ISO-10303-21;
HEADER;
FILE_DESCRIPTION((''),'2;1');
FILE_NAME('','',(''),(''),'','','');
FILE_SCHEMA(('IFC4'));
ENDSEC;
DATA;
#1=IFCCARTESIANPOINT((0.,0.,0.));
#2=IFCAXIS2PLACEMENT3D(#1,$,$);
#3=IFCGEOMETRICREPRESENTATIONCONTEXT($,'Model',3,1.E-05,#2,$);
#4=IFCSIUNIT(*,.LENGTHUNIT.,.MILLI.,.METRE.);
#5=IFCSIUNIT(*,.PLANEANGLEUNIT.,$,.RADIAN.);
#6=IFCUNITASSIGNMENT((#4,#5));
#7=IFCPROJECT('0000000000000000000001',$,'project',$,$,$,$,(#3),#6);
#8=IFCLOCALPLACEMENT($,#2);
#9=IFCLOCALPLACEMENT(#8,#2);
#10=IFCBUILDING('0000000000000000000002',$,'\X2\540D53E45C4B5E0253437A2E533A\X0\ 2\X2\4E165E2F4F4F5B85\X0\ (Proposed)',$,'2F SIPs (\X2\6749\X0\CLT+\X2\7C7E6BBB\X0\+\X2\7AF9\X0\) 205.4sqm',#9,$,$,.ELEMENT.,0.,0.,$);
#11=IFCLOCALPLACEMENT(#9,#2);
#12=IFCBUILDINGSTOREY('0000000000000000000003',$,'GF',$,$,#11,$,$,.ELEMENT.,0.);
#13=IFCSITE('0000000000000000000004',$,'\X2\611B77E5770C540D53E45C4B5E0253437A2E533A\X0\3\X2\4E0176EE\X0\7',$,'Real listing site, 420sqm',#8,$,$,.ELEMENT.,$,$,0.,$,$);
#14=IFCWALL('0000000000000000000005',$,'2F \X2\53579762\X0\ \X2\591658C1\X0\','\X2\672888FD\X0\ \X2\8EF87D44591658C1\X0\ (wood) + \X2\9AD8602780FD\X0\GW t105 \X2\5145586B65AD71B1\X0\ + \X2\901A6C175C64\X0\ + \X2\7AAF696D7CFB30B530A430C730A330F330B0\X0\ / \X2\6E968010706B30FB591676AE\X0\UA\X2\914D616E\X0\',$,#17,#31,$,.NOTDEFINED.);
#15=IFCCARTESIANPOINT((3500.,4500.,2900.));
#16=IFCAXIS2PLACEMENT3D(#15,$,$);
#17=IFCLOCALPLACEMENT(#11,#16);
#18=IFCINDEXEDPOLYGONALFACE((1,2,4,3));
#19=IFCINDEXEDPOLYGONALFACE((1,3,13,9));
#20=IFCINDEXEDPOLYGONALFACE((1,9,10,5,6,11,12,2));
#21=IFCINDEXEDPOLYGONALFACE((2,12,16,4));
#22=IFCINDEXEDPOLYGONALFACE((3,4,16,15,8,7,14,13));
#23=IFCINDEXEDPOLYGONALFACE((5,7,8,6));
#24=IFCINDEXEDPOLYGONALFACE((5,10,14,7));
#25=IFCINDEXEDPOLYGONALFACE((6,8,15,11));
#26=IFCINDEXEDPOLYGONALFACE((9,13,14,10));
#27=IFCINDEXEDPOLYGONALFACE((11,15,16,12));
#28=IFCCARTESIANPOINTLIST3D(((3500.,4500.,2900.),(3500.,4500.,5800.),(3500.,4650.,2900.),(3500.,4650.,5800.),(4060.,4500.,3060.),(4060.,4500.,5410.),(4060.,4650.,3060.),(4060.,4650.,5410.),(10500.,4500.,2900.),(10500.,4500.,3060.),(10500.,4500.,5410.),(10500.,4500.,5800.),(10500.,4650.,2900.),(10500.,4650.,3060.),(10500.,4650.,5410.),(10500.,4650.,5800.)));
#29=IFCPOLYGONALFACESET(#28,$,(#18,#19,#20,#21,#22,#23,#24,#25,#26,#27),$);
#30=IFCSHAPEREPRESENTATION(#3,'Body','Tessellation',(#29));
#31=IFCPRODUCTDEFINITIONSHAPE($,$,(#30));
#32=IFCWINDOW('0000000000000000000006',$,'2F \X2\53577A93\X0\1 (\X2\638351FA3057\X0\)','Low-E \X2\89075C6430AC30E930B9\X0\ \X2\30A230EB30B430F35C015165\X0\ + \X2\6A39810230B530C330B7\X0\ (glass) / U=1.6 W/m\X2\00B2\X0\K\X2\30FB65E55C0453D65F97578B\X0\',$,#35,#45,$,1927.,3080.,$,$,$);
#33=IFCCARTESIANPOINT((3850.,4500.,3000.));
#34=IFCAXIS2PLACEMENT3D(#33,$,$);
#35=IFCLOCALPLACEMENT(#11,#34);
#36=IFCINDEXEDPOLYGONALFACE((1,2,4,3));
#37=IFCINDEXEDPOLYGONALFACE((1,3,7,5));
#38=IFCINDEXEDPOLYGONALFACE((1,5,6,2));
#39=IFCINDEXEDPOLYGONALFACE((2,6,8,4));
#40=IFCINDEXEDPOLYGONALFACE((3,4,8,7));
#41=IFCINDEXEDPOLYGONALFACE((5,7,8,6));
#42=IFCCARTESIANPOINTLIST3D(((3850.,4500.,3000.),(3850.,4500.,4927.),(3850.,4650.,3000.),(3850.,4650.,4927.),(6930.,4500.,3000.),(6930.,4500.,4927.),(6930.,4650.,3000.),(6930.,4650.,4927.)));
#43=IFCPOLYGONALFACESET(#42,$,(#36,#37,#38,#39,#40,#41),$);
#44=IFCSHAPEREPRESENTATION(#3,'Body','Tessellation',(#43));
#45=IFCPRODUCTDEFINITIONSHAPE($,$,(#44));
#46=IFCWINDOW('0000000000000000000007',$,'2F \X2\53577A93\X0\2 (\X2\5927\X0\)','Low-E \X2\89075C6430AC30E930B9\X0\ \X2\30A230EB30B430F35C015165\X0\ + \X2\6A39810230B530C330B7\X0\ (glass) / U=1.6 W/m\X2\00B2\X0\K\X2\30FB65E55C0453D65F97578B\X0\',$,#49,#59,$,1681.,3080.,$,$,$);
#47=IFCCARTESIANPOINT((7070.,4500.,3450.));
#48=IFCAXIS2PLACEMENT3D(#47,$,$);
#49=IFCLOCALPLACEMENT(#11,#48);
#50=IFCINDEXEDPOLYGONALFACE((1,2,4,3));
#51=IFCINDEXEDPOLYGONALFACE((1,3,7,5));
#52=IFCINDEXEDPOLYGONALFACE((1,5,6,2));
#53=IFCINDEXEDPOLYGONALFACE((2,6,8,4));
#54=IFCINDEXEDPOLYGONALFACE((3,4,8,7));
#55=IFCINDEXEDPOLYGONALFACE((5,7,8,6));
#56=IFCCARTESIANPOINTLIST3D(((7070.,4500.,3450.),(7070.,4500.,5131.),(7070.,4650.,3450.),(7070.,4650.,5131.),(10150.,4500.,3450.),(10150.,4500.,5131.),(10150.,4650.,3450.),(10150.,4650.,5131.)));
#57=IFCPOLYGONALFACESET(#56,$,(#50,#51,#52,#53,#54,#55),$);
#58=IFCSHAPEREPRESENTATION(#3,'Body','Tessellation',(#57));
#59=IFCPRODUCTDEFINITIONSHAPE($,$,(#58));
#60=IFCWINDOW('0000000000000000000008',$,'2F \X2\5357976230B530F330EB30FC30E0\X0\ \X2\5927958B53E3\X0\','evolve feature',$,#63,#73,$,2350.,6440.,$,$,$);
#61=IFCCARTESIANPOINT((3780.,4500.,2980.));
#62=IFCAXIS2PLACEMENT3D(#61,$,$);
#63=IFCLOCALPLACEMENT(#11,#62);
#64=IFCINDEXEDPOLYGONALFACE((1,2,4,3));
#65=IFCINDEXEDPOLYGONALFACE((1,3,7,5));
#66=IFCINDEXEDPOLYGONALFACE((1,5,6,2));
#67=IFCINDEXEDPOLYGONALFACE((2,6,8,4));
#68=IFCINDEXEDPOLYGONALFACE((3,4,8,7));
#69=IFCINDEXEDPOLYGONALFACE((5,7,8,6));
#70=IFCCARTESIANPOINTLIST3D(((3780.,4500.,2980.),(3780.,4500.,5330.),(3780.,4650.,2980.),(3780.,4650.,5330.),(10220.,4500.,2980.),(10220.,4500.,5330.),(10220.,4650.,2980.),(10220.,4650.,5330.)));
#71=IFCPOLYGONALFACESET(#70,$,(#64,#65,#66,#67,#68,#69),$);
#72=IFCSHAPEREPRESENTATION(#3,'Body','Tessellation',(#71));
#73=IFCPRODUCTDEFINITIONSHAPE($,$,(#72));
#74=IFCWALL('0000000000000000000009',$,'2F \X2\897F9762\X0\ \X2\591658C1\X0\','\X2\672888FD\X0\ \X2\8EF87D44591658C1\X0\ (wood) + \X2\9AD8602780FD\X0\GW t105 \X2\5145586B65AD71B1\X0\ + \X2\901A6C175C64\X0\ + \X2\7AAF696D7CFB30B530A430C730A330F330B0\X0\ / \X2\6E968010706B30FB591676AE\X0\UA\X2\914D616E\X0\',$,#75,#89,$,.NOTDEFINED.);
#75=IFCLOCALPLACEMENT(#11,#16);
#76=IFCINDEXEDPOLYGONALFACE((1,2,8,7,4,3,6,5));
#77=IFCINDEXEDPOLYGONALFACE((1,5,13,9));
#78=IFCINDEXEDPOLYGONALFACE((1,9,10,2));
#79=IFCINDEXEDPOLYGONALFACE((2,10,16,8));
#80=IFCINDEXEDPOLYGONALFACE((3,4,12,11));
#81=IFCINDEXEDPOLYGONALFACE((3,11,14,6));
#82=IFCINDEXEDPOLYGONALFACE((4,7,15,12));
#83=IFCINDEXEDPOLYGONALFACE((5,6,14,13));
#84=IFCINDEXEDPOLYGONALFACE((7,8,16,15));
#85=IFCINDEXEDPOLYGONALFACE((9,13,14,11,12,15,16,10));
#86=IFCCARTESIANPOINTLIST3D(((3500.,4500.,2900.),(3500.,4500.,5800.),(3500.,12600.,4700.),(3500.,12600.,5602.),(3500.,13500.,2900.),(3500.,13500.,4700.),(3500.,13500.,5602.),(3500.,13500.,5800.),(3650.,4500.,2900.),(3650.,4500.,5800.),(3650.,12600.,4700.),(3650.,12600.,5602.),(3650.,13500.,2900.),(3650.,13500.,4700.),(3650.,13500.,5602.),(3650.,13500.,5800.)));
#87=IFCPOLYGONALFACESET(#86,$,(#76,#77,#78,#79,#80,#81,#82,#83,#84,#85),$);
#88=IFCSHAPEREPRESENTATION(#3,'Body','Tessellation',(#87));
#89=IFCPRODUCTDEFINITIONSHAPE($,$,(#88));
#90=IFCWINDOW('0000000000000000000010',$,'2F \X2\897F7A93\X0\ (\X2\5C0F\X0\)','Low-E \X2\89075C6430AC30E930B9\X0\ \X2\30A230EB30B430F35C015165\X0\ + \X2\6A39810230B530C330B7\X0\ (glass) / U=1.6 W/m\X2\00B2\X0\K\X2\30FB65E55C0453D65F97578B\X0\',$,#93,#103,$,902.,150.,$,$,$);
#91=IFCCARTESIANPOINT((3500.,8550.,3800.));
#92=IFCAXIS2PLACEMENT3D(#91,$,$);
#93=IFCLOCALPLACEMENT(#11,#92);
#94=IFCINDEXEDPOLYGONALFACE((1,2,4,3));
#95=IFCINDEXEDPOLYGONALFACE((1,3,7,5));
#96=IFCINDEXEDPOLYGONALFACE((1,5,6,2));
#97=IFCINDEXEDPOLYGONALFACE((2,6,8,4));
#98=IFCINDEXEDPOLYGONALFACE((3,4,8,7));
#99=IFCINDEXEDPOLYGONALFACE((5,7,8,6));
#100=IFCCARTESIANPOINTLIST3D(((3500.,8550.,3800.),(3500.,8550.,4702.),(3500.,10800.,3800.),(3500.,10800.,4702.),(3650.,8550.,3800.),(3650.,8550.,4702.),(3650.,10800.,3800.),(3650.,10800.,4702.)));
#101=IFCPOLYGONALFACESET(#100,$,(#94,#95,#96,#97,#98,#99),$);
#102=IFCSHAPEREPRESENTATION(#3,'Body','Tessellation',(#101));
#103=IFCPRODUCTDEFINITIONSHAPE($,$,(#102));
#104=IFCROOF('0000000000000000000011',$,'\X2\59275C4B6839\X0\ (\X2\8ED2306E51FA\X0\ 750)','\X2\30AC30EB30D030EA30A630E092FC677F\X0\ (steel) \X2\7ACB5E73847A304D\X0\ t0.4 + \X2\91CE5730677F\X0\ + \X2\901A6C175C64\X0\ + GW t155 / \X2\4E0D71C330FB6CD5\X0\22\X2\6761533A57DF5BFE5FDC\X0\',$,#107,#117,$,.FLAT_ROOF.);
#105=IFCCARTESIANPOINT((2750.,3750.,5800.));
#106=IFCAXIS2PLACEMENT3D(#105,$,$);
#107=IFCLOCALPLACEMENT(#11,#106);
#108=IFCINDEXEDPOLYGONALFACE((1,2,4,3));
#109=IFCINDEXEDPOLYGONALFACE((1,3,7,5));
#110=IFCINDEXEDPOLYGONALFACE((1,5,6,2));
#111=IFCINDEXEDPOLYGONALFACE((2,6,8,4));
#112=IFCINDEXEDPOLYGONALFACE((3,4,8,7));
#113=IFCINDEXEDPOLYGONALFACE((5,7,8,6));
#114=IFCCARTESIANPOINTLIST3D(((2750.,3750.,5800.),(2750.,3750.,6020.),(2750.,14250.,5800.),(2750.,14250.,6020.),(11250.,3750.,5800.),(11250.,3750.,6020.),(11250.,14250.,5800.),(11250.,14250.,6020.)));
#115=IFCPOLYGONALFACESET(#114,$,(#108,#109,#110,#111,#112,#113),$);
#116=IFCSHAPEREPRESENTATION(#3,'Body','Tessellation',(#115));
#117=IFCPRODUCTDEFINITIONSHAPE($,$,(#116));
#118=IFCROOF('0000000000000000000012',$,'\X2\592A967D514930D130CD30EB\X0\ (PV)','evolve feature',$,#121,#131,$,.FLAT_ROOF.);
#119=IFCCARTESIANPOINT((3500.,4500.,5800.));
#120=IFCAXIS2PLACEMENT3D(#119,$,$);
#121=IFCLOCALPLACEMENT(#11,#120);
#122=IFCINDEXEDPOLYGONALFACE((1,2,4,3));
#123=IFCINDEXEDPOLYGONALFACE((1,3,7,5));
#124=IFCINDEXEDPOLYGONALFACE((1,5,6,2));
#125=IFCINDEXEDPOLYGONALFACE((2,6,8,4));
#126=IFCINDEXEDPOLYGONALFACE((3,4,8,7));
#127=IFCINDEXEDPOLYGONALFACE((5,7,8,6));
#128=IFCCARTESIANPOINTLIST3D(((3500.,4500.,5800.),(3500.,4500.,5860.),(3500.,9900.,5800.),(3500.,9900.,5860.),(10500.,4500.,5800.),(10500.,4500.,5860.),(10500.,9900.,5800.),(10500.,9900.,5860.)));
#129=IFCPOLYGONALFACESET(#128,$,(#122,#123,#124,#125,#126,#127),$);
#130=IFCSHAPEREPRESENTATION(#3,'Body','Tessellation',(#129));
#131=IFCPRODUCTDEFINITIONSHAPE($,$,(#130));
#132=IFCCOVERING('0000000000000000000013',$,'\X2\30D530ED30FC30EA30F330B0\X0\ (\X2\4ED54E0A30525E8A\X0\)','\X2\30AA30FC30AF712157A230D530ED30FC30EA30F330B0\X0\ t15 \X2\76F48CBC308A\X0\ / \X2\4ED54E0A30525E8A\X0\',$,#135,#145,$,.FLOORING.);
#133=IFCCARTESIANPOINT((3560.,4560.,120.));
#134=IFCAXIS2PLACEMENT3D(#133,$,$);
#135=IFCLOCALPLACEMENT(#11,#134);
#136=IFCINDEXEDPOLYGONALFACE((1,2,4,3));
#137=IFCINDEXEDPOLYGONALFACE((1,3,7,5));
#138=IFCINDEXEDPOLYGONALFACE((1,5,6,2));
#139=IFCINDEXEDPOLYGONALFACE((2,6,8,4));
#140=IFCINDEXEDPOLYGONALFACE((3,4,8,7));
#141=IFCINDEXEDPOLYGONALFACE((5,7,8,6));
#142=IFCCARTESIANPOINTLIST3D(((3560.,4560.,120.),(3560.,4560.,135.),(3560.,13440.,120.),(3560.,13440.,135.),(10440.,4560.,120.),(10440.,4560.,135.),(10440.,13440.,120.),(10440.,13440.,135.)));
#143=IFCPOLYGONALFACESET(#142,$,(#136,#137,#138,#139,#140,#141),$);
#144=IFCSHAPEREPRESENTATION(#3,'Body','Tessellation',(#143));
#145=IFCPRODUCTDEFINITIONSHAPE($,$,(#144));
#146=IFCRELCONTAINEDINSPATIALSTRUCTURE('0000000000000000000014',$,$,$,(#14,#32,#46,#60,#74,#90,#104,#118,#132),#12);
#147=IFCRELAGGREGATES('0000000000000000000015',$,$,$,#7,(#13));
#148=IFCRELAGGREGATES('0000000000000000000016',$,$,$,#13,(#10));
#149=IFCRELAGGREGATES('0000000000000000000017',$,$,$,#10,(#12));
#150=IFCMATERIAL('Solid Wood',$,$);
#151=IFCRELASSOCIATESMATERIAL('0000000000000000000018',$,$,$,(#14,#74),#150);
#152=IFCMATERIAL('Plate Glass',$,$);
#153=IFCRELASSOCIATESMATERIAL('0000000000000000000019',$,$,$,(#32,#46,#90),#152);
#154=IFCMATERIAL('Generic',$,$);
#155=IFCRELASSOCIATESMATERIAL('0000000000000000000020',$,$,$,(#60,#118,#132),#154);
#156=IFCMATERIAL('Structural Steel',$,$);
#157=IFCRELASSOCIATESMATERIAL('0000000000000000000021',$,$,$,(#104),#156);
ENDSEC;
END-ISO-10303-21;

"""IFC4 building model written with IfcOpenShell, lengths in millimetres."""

from ifc_helpers import new_model, si_unit, frame, frame_2d, origin, place, context, project, spatial, rectangle, extrude, material, element, fill, save


model = new_model("IFC4")

# Units and contexts
model_context = context("Model", 3, precision=1e-05, world=origin())
ifc_project = project(units=[si_unit("LENGTHUNIT", "METRE", prefix="MILLI"), si_unit("PLANEANGLEUNIT", "RADIAN")], contexts=[model_context])

# Site, building, storey
site_placement = place(None, origin())
site = spatial("IfcSite", under=ifc_project, at=site_placement, Name="愛知県名古屋市千種区3丁目7", ObjectType="Real listing site, 420sqm", CompositionType="ELEMENT", RefElevation=0.0)
building_placement = place(site_placement, origin())
building = spatial("IfcBuilding", under=site, at=building_placement, Name="名古屋市千種区 2世帯住宅 (Proposed)", ObjectType="2F SIPs (杉CLT+籾殻+竹) 205.4sqm", CompositionType="ELEMENT", ElevationOfRefHeight=0.0, ElevationOfTerrain=0.0)
storey_placement = place(building_placement, origin())
storey = spatial("IfcBuildingStorey", under=building, at=storey_placement, Name="GF", CompositionType="ELEMENT", Elevation=0.0)

# Shared definitions
ifc_material_1 = material(Name="Solid Wood")

# Shared definitions
ifc_material_2 = material(Name="Plate Glass")
ifc_material_3 = material(Name="Generic")

# Wall, openings, windows
wall_1_placement = place(storey_placement, frame((3500.0, 4500.0, 2900.0)))
wall_1 = element("IfcWall", 1, at=wall_1_placement, inside=storey, material=ifc_material_1, Name="2F 南面 外壁", Description="木製 軸組外壁 (wood) + 高性能GW t105 充填断熱 + 通気層 + 窯業系サイディング / 準耐火・外皮UA配慮", PredefinedType="NOTDEFINED", context=model_context, shape_type="SweptSolid", body=[
    extrude(rectangle(XDim=7000.0, YDim=150.0, at=frame_2d((3500.0, 75.0))), frame((3500.0, 4500.0, 2900.0)), (0.0, 0.0, 1.0), 2900.0),
])
opening_1_placement = place(storey_placement, frame((3850.0, 4500.0, 3000.0)))
opening_1 = element("IfcOpeningElement", 2, at=opening_1_placement, cuts=wall_1, PredefinedType="NOTDEFINED", context=model_context, shape_type="SweptSolid", body=[
    extrude(rectangle(XDim=3080.0, YDim=150.0, at=frame_2d((1540.0, 75.0))), frame((3850.0, 4500.0, 3000.0)), (0.0, 0.0, 1.0), 1927.0),
])
opening_2_placement = place(storey_placement, frame((7070.0, 4500.0, 3450.0)))
opening_2 = element("IfcOpeningElement", 3, at=opening_2_placement, cuts=wall_1, PredefinedType="NOTDEFINED", context=model_context, shape_type="SweptSolid", body=[
    extrude(rectangle(XDim=3080.0, YDim=150.0, at=frame_2d((1540.0, 75.0))), frame((7070.0, 4500.0, 3450.0)), (0.0, 0.0, 1.0), 1681.0),
])
opening_3_placement = place(storey_placement, frame((3780.0, 4500.0, 2980.0)))
opening_3 = element("IfcOpeningElement", 4, at=opening_3_placement, cuts=wall_1, PredefinedType="NOTDEFINED", context=model_context, shape_type="SweptSolid", body=[
    extrude(rectangle(XDim=6440.0, YDim=150.0, at=frame_2d((3220.0, 75.0))), frame((3780.0, 4500.0, 2980.0)), (0.0, 0.0, 1.0), 2350.0),
])
window_1_placement = place(storey_placement, frame((3850.0, 4500.0, 3000.0)))
window_1 = element("IfcWindow", 5, at=window_1_placement, inside=storey, material=ifc_material_2, Name="2F 南窓1 (掃出し)", Description="Low-E 複層ガラス アルゴン封入 + 樹脂サッシ (glass) / U=1.6 W/m²K・日射取得型", OverallHeight=1927.0, OverallWidth=3080.0, context=model_context, shape_type="SweptSolid", body=[
    extrude(rectangle(XDim=3080.0, YDim=150.0, at=frame_2d((1540.0, 75.0))), frame((3850.0, 4500.0, 3000.0)), (0.0, 0.0, 1.0), 1927.0),
])
fill(opening_1, window_1)
window_2_placement = place(storey_placement, frame((7070.0, 4500.0, 3450.0)))
window_2 = element("IfcWindow", 6, at=window_2_placement, inside=storey, material=ifc_material_2, Name="2F 南窓2 (大)", Description="Low-E 複層ガラス アルゴン封入 + 樹脂サッシ (glass) / U=1.6 W/m²K・日射取得型", OverallHeight=1681.0, OverallWidth=3080.0, context=model_context, shape_type="SweptSolid", body=[
    extrude(rectangle(XDim=3080.0, YDim=150.0, at=frame_2d((1540.0, 75.0))), frame((7070.0, 4500.0, 3450.0)), (0.0, 0.0, 1.0), 1681.0),
])
fill(opening_2, window_2)
window_3_placement = place(storey_placement, frame((3780.0, 4500.0, 2980.0)))
window_3 = element("IfcWindow", 7, at=window_3_placement, inside=storey, material=ifc_material_3, Name="2F 南面サンルーム 大開口", Description="evolve feature", OverallHeight=2350.0, OverallWidth=6440.0, context=model_context, shape_type="SweptSolid", body=[
    extrude(rectangle(XDim=6440.0, YDim=150.0, at=frame_2d((3220.0, 75.0))), frame((3780.0, 4500.0, 2980.0)), (0.0, 0.0, 1.0), 2350.0),
])
fill(opening_3, window_3)

# Wall, opening, window
wall_2_placement = place(storey_placement, frame((3500.0, 4500.0, 2900.0)))
wall_2 = element("IfcWall", 8, at=wall_2_placement, inside=storey, material=ifc_material_1, Name="2F 西面 外壁", Description="木製 軸組外壁 (wood) + 高性能GW t105 充填断熱 + 通気層 + 窯業系サイディング / 準耐火・外皮UA配慮", PredefinedType="NOTDEFINED", context=model_context, shape_type="SweptSolid", body=[
    extrude(rectangle(XDim=150.0, YDim=9000.0, at=frame_2d((75.0, 4500.0))), frame((3500.0, 4500.0, 2900.0)), (0.0, 0.0, 1.0), 2900.0),
])
opening_4_placement = place(storey_placement, frame((3500.0, 8550.0, 3800.0)))
opening_4 = element("IfcOpeningElement", 9, at=opening_4_placement, cuts=wall_2, PredefinedType="NOTDEFINED", context=model_context, shape_type="SweptSolid", body=[
    extrude(rectangle(XDim=150.0, YDim=2250.0, at=frame_2d((75.0, 1125.0))), frame((3500.0, 8550.0, 3800.0)), (0.0, 0.0, 1.0), 902.0),
])
window_4_placement = place(storey_placement, frame((3500.0, 8550.0, 3800.0)))
window_4 = element("IfcWindow", 10, at=window_4_placement, inside=storey, material=ifc_material_2, Name="2F 西窓 (小)", Description="Low-E 複層ガラス アルゴン封入 + 樹脂サッシ (glass) / U=1.6 W/m²K・日射取得型", OverallHeight=902.0, OverallWidth=150.0, context=model_context, shape_type="SweptSolid", body=[
    extrude(rectangle(XDim=150.0, YDim=2250.0, at=frame_2d((75.0, 1125.0))), frame((3500.0, 8550.0, 3800.0)), (0.0, 0.0, 1.0), 902.0),
])
fill(opening_4, window_4)

# Roofs
ifc_material_4 = material(Name="Structural Steel")
roof_1_placement = place(storey_placement, frame((2750.0, 3750.0, 5800.0)))
element("IfcRoof", 11, at=roof_1_placement, inside=storey, material=ifc_material_4, Name="大屋根 (軒の出 750)", Description="ガルバリウム鋼板 (steel) 立平葺き t0.4 + 野地板 + 通気層 + GW t155 / 不燃・法22条区域対応", PredefinedType="FLAT_ROOF", context=model_context, shape_type="SweptSolid", body=[
    extrude(rectangle(XDim=8500.0, YDim=10500.0, at=frame_2d((4250.0, 5250.0))), frame((2750.0, 3750.0, 5800.0)), (0.0, 0.0, 1.0), 220.0),
])
roof_2_placement = place(storey_placement, frame((3500.0, 4500.0, 5800.0)))
element("IfcRoof", 12, at=roof_2_placement, inside=storey, material=ifc_material_3, Name="太陽光パネル (PV)", Description="evolve feature", PredefinedType="FLAT_ROOF", context=model_context, shape_type="SweptSolid", body=[
    extrude(rectangle(XDim=7000.0, YDim=5400.0, at=frame_2d((3500.0, 2700.0))), frame((3500.0, 4500.0, 5800.0)), (0.0, 0.0, 1.0), 60.0),
])

# Covering
covering_placement = place(storey_placement, frame((3560.0, 4560.0, 120.0)))
element("IfcCovering", 13, at=covering_placement, inside=storey, material=ifc_material_3, Name="フローリング (仕上げ床)", Description="オーク無垢フローリング t15 直貼り / 仕上げ床", PredefinedType="FLOORING", context=model_context, shape_type="SweptSolid", body=[
    extrude(rectangle(XDim=6880.0, YDim=8880.0, at=frame_2d((3440.0, 4440.0))), frame((3560.0, 4560.0, 120.0)), (0.0, 0.0, 1.0), 15.0),
])

save(model, "model.ifc")
